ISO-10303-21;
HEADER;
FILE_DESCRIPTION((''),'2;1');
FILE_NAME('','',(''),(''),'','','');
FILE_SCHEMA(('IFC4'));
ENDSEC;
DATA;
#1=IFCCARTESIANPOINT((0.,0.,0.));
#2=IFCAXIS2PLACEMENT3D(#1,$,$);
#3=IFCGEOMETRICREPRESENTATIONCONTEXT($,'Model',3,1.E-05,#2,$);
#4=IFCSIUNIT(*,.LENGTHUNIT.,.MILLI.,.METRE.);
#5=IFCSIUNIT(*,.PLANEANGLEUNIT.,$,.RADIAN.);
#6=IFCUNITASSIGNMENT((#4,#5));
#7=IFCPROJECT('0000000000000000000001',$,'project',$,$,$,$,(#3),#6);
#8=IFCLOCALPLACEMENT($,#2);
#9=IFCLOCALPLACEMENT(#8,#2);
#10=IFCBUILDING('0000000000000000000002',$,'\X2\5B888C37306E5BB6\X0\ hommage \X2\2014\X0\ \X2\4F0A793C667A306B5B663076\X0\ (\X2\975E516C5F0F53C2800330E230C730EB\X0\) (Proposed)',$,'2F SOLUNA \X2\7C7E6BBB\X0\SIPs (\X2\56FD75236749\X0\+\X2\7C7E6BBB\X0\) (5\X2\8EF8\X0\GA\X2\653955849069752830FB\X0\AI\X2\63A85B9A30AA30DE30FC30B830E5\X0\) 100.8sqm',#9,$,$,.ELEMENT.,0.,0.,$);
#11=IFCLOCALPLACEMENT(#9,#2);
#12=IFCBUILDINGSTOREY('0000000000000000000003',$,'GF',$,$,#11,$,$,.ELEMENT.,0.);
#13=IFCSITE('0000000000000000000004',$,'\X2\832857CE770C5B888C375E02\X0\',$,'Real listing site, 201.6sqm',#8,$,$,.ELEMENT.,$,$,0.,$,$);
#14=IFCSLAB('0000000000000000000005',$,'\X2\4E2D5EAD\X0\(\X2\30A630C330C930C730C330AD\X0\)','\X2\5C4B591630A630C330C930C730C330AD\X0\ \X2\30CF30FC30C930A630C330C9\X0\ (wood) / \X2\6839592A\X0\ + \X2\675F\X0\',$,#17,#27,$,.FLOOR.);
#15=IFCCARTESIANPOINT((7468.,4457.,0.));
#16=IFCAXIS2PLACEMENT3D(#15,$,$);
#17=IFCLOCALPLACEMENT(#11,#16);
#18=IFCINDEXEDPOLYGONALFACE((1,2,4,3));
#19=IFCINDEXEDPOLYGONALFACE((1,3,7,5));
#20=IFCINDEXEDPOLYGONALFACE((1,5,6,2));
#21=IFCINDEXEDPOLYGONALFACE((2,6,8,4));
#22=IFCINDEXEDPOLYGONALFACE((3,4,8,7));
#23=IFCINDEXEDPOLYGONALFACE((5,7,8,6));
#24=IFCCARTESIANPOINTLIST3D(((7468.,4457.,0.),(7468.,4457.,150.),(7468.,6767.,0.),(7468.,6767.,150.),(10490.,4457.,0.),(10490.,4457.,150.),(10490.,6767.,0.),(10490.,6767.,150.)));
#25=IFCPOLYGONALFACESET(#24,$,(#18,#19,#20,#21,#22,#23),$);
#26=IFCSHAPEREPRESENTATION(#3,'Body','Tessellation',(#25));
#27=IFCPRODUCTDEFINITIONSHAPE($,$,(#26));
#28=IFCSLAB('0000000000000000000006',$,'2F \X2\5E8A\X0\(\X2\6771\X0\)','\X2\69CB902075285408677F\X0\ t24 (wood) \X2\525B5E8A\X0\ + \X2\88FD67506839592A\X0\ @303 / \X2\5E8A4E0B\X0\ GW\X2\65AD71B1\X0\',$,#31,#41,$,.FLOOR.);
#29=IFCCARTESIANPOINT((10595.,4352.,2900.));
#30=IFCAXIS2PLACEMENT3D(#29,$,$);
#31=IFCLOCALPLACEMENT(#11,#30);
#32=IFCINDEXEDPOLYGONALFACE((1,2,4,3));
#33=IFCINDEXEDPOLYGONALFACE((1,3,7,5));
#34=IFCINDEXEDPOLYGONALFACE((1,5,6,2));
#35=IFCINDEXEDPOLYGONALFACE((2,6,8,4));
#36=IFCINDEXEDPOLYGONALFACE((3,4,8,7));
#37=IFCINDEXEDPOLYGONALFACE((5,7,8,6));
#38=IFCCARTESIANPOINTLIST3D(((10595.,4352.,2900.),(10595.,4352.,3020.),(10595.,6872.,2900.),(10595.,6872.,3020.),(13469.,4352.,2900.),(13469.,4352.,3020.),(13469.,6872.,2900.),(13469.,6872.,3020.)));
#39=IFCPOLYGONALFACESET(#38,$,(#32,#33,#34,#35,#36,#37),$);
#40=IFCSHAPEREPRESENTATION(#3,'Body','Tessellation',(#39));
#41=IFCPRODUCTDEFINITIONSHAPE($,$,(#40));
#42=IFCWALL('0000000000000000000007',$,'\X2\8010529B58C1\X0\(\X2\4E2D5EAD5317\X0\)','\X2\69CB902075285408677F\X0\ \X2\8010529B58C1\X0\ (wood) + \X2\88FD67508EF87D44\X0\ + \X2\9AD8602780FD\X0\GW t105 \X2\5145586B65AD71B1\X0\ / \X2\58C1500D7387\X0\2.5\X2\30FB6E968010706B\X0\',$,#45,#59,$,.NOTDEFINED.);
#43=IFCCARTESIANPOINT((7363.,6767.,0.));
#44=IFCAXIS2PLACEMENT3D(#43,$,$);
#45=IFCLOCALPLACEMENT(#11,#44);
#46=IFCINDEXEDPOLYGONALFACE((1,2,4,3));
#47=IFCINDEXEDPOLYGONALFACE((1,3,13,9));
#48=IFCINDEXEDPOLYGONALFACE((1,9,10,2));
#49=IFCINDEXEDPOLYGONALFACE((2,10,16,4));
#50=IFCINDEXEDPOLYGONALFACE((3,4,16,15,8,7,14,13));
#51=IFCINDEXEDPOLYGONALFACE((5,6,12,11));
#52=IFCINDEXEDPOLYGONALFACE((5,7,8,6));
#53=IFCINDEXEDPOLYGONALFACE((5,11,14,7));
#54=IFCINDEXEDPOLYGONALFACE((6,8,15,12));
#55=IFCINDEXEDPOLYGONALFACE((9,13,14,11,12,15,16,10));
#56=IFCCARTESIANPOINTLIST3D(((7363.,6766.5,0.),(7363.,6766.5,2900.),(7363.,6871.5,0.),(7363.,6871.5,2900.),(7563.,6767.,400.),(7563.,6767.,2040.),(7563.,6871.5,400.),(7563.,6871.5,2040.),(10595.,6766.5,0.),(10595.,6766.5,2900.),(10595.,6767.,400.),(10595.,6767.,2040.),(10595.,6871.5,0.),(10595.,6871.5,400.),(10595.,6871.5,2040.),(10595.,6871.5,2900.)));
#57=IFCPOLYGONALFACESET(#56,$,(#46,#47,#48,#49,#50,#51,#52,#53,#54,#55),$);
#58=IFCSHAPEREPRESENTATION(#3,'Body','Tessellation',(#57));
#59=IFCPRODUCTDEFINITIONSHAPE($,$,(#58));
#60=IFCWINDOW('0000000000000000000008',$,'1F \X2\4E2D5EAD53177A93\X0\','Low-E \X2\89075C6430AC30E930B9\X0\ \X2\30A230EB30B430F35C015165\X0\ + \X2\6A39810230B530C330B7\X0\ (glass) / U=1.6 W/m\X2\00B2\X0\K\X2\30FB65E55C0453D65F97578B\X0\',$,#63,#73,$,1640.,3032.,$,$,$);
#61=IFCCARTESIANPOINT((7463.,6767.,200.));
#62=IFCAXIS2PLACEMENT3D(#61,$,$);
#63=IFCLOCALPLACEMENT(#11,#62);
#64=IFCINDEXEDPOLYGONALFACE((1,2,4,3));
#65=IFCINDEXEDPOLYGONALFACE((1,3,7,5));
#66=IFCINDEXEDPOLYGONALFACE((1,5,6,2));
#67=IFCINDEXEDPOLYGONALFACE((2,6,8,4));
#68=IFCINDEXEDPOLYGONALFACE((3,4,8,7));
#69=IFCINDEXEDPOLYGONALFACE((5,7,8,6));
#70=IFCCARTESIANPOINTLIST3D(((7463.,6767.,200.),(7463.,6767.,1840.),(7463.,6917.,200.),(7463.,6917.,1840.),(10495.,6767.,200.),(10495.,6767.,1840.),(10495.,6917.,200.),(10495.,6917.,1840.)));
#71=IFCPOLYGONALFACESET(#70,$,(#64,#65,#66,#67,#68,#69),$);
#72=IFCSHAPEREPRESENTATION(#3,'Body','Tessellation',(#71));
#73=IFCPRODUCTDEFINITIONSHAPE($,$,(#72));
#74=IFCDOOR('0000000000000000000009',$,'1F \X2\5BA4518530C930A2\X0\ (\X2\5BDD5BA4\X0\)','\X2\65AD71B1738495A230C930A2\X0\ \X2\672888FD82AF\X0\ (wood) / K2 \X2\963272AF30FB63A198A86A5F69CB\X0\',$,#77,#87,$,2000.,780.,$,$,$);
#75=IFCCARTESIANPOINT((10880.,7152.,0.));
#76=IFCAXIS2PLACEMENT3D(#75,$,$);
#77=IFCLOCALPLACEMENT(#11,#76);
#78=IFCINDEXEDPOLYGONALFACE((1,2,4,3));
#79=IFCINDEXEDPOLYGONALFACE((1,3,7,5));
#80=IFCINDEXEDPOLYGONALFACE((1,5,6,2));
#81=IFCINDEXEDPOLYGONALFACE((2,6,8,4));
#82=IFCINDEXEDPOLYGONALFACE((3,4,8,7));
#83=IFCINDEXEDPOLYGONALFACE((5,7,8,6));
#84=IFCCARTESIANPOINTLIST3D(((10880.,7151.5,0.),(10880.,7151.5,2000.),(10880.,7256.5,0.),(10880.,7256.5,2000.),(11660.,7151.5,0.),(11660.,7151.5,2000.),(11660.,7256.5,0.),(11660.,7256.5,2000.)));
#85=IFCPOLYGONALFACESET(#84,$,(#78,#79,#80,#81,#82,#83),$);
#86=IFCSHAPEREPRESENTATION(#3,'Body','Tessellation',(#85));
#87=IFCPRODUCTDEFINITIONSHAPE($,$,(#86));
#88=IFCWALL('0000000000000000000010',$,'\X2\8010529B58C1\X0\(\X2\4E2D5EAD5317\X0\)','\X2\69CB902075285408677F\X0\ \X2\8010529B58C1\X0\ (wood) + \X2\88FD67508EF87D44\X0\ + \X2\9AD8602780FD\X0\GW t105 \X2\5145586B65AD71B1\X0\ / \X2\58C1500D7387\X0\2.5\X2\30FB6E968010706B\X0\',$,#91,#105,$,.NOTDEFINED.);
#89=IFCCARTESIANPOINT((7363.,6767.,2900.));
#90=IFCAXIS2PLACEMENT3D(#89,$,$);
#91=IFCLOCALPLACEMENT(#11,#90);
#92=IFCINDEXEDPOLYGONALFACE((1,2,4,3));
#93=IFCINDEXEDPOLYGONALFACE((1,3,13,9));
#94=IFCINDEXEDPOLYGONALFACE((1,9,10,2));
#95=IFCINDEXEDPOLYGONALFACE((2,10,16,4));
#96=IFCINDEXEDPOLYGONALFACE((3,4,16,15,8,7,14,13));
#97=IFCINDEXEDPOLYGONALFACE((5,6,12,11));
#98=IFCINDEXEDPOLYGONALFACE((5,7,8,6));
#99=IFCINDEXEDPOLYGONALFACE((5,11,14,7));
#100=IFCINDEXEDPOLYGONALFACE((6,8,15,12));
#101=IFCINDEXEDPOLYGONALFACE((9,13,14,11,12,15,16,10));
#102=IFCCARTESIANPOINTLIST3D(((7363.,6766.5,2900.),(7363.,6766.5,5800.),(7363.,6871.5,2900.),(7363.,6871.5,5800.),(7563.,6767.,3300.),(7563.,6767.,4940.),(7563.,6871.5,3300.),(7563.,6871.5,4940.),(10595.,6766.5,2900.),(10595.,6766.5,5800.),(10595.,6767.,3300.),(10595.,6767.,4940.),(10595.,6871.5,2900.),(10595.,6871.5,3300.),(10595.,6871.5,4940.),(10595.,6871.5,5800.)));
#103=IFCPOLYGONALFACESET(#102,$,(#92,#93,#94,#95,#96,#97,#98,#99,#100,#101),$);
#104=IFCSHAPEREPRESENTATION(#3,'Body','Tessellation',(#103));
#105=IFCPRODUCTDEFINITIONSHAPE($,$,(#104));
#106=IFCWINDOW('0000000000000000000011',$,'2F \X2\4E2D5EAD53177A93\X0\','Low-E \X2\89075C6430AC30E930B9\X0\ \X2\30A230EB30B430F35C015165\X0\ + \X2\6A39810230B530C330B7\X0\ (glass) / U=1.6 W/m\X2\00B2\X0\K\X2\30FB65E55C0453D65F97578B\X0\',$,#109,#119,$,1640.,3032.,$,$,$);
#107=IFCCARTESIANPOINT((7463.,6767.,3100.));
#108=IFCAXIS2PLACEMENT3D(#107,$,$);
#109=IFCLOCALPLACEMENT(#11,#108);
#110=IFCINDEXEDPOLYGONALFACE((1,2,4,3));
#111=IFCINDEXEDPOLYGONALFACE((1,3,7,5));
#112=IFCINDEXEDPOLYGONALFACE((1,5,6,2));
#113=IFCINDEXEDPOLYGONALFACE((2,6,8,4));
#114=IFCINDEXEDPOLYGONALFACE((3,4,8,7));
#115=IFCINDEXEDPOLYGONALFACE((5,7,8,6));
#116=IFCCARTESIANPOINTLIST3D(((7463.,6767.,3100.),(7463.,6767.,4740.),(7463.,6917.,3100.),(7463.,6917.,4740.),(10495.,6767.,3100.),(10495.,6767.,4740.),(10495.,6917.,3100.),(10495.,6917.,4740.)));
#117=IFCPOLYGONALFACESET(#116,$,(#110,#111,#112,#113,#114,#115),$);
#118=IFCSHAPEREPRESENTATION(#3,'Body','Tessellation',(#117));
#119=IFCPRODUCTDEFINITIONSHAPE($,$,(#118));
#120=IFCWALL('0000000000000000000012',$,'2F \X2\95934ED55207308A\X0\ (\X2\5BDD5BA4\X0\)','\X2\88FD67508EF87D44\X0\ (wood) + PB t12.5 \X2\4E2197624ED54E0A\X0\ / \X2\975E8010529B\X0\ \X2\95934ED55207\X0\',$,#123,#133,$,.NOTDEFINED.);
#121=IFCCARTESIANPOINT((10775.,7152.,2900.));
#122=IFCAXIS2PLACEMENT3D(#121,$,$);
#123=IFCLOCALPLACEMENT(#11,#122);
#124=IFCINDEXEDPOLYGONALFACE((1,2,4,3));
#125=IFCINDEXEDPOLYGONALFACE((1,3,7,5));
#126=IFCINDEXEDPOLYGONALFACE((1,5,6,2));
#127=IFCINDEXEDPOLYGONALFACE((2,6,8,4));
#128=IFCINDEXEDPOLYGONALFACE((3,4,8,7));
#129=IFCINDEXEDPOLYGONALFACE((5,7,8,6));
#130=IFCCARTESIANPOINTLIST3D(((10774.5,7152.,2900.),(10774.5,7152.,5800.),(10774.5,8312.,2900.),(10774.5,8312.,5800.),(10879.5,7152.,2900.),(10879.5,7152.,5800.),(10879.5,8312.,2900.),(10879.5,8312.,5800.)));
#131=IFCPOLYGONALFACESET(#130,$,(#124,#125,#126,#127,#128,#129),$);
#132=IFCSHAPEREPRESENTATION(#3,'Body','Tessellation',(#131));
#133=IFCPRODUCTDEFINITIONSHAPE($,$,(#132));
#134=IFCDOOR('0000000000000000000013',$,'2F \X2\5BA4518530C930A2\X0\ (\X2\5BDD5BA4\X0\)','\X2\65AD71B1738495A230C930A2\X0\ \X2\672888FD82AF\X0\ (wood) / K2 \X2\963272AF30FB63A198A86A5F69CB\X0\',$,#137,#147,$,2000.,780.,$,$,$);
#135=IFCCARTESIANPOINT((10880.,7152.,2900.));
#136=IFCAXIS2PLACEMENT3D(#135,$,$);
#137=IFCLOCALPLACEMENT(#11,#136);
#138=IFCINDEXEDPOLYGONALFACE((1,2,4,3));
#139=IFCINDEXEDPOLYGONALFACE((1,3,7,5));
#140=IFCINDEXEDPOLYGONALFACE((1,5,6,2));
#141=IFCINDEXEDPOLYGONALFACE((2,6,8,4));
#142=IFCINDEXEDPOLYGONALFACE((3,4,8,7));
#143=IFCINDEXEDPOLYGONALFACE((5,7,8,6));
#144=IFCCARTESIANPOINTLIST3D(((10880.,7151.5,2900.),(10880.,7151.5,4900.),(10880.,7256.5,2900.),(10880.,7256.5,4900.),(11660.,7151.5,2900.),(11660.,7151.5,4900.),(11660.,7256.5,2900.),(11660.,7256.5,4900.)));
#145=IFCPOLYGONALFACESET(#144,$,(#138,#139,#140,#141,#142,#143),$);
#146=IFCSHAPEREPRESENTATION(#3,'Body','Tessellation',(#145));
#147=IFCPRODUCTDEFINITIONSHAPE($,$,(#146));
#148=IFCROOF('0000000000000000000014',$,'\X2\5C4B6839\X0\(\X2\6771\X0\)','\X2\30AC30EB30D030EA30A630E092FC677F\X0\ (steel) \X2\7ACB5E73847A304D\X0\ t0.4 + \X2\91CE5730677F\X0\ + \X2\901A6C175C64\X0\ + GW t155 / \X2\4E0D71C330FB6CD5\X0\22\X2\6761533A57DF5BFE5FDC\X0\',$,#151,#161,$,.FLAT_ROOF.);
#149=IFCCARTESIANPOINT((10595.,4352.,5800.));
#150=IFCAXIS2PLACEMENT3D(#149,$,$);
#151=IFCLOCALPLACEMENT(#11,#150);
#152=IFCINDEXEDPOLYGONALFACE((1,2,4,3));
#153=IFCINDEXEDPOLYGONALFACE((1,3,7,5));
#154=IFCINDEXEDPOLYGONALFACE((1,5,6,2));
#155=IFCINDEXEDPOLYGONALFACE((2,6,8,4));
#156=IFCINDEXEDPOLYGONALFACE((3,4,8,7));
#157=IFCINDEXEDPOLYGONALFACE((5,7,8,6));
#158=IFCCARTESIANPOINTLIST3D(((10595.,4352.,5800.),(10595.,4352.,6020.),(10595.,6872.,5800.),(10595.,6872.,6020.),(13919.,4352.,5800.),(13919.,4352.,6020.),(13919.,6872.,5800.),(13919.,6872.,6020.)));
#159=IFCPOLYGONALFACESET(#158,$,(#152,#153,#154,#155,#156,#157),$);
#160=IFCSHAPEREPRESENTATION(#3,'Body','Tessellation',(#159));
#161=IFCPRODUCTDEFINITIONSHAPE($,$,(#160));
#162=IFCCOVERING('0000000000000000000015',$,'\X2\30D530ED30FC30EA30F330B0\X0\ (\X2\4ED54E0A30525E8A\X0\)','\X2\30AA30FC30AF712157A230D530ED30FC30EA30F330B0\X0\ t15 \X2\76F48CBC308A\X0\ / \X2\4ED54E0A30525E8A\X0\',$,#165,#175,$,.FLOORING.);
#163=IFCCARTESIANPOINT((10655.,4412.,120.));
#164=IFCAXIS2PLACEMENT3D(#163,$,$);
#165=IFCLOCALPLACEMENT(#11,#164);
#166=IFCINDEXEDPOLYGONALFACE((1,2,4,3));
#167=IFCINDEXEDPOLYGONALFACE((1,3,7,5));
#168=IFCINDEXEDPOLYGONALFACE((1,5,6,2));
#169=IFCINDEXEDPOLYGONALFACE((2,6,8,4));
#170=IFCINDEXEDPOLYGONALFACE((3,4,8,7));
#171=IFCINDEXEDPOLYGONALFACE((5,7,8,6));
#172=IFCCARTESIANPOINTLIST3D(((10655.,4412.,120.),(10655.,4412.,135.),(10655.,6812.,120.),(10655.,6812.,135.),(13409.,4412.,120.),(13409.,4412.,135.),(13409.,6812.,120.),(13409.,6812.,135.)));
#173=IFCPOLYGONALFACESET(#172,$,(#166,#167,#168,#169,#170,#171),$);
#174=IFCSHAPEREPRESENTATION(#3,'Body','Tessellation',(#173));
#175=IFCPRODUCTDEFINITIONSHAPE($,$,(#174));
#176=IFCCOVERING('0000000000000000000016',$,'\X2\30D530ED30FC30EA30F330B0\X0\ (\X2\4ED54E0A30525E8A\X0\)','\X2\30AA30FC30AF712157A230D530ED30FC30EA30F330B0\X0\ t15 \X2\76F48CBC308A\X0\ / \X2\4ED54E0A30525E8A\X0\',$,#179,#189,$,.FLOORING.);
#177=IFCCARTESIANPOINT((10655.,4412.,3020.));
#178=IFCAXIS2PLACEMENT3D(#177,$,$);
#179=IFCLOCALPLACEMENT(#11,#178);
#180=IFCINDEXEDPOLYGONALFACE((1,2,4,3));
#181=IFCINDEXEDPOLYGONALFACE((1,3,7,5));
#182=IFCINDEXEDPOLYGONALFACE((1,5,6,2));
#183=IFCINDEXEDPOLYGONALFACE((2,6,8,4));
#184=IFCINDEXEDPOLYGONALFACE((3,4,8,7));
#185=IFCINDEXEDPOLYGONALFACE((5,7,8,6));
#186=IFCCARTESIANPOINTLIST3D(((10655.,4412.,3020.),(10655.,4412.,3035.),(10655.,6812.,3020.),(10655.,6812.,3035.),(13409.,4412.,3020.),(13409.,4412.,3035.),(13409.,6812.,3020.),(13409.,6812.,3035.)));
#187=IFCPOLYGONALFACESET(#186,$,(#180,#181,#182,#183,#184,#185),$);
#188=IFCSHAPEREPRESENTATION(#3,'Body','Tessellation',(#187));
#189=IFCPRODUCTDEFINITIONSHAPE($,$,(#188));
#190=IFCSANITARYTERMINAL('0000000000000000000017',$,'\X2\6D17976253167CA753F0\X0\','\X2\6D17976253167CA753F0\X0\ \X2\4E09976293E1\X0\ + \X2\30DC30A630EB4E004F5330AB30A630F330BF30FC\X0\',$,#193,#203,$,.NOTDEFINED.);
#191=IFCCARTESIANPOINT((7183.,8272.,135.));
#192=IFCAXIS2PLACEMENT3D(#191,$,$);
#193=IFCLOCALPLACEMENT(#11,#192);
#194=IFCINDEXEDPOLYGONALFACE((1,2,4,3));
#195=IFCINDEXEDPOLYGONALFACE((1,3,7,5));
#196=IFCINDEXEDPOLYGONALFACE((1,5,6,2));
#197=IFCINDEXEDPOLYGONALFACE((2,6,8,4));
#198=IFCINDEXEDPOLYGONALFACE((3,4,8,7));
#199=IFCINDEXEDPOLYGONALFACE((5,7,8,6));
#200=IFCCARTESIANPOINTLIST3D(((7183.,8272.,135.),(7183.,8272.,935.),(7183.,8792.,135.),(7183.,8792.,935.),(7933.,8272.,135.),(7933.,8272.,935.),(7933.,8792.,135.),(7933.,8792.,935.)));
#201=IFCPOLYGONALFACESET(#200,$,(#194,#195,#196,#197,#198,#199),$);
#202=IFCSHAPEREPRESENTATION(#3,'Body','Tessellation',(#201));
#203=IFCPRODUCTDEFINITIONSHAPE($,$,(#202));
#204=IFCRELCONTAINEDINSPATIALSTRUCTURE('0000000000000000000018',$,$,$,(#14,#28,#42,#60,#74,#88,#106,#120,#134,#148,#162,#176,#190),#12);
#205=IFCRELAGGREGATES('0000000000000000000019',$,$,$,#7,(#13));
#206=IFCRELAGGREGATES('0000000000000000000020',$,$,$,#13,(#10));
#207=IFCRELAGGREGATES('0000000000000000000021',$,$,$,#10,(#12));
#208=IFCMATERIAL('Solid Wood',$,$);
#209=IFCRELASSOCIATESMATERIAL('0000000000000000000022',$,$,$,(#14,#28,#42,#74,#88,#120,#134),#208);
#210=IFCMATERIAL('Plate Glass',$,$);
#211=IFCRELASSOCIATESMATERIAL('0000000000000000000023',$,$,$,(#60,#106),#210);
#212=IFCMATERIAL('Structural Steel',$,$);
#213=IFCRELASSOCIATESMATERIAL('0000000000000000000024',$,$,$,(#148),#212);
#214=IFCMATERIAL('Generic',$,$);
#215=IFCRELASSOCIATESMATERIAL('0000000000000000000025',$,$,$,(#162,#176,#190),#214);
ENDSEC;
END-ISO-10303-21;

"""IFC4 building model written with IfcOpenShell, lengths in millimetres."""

from ifc_helpers import new_model, si_unit, frame, frame_2d, origin, place, context, project, spatial, rectangle, extrude, material, element, fill, save


model = new_model("IFC4")

# Units and contexts
model_context = context("Model", 3, precision=1e-05, world=origin())
ifc_project = project(units=[si_unit("LENGTHUNIT", "METRE", prefix="MILLI"), si_unit("PLANEANGLEUNIT", "RADIAN")], contexts=[model_context])

# Site, building, storey
site_placement = place(None, origin())
site = spatial("IfcSite", under=ifc_project, at=site_placement, Name="茨城県守谷市", ObjectType="Real listing site, 201.6sqm", CompositionType="ELEMENT", RefElevation=0.0)
building_placement = place(site_placement, origin())
building = spatial("IfcBuilding", under=site, at=building_placement, Name="守谷の家 hommage — 伊礼智に学ぶ (非公式参考モデル) (Proposed)", ObjectType="2F SOLUNA 籾殻SIPs (国産杉+籾殻) (5軸GA改善適用・AI推定オマージュ) 100.8sqm", CompositionType="ELEMENT", ElevationOfRefHeight=0.0, ElevationOfTerrain=0.0)
storey_placement = place(building_placement, origin())
storey = spatial("IfcBuildingStorey", under=building, at=storey_placement, Name="GF", CompositionType="ELEMENT", Elevation=0.0)

# Slabs
ifc_material_1 = material(Name="Solid Wood")
slab_1_placement = place(storey_placement, frame((7468.0, 4457.0, 0.0)))
element("IfcSlab", 1, at=slab_1_placement, inside=storey, material=ifc_material_1, Name="中庭(ウッドデッキ)", Description="屋外ウッドデッキ ハードウッド (wood) / 根太 + 束", PredefinedType="FLOOR", context=model_context, shape_type="SweptSolid", body=[
    extrude(rectangle(XDim=3022.0, YDim=2310.0, at=frame_2d((1511.0, 1155.0))), frame((7468.0, 4457.0, 0.0)), (0.0, 0.0, 1.0), 150.0),
])
slab_2_placement = place(storey_placement, frame((10595.0, 4352.0, 2900.0)))
element("IfcSlab", 2, at=slab_2_placement, inside=storey, material=ifc_material_1, Name="2F 床(東)", Description="構造用合板 t24 (wood) 剛床 + 製材根太 @303 / 床下 GW断熱", PredefinedType="FLOOR", context=model_context, shape_type="SweptSolid", body=[
    extrude(rectangle(XDim=2874.0, YDim=2520.0, at=frame_2d((1437.0, 1260.0))), frame((10595.0, 4352.0, 2900.0)), (0.0, 0.0, 1.0), 120.0),
])

# Wall, opening, window
wall_1_placement = place(storey_placement, frame((7363.0, 6767.0, 0.0)))
wall_1 = element("IfcWall", 3, at=wall_1_placement, inside=storey, material=ifc_material_1, Name="耐力壁(中庭北)", Description="構造用合板 耐力壁 (wood) + 製材軸組 + 高性能GW t105 充填断熱 / 壁倍率2.5・準耐火", PredefinedType="NOTDEFINED", context=model_context, shape_type="SweptSolid", body=[
    extrude(rectangle(XDim=3232.0, YDim=105.0, at=frame_2d((1616.0, 52.0))), frame((7363.0, 6767.0, 0.0)), (0.0, 0.0, 1.0), 2900.0),
])
opening_1_placement = place(storey_placement, frame((7463.0, 6767.0, 200.0)))
opening_1 = element("IfcOpeningElement", 4, at=opening_1_placement, cuts=wall_1, PredefinedType="NOTDEFINED", context=model_context, shape_type="SweptSolid", body=[
    extrude(rectangle(XDim=3032.0, YDim=150.0, at=frame_2d((1516.0, 75.0))), frame((7463.0, 6767.0, 200.0)), (0.0, 0.0, 1.0), 1640.0),
])
ifc_material_2 = material(Name="Plate Glass")
window_1_placement = place(storey_placement, frame((7463.0, 6767.0, 200.0)))
window_1 = element("IfcWindow", 5, at=window_1_placement, inside=storey, material=ifc_material_2, Name="1F 中庭北窓", Description="Low-E 複層ガラス アルゴン封入 + 樹脂サッシ (glass) / U=1.6 W/m²K・日射取得型", OverallHeight=1640.0, OverallWidth=3032.0, context=model_context, shape_type="SweptSolid", body=[
    extrude(rectangle(XDim=3032.0, YDim=150.0, at=frame_2d((1516.0, 75.0))), frame((7463.0, 6767.0, 200.0)), (0.0, 0.0, 1.0), 1640.0),
])
fill(opening_1, window_1)

# Door
door_1_placement = place(storey_placement, frame((10880.0, 7152.0, 0.0)))
element("IfcDoor", 6, at=door_1_placement, inside=storey, material=ifc_material_1, Name="1F 室内ドア (寝室)", Description="断熱玄関ドア 木製芯 (wood) / K2 防犯・採風機構", OverallHeight=2000.0, OverallWidth=780.0, context=model_context, shape_type="SweptSolid", body=[
    extrude(rectangle(XDim=780.0, YDim=105.0, at=frame_2d((390.0, 52.0))), frame((10880.0, 7152.0, 0.0)), (0.0, 0.0, 1.0), 2000.0),
])

# Wall, opening, window
wall_2_placement = place(storey_placement, frame((7363.0, 6767.0, 2900.0)))
wall_2 = element("IfcWall", 7, at=wall_2_placement, inside=storey, material=ifc_material_1, Name="耐力壁(中庭北)", Description="構造用合板 耐力壁 (wood) + 製材軸組 + 高性能GW t105 充填断熱 / 壁倍率2.5・準耐火", PredefinedType="NOTDEFINED", context=model_context, shape_type="SweptSolid", body=[
    extrude(rectangle(XDim=3232.0, YDim=105.0, at=frame_2d((1616.0, 52.0))), frame((7363.0, 6767.0, 2900.0)), (0.0, 0.0, 1.0), 2900.0),
])
opening_2_placement = place(storey_placement, frame((7463.0, 6767.0, 3100.0)))
opening_2 = element("IfcOpeningElement", 8, at=opening_2_placement, cuts=wall_2, PredefinedType="NOTDEFINED", context=model_context, shape_type="SweptSolid", body=[
    extrude(rectangle(XDim=3032.0, YDim=150.0, at=frame_2d((1516.0, 75.0))), frame((7463.0, 6767.0, 3100.0)), (0.0, 0.0, 1.0), 1640.0),
])
window_2_placement = place(storey_placement, frame((7463.0, 6767.0, 3100.0)))
window_2 = element("IfcWindow", 9, at=window_2_placement, inside=storey, material=ifc_material_2, Name="2F 中庭北窓", Description="Low-E 複層ガラス アルゴン封入 + 樹脂サッシ (glass) / U=1.6 W/m²K・日射取得型", OverallHeight=1640.0, OverallWidth=3032.0, context=model_context, shape_type="SweptSolid", body=[
    extrude(rectangle(XDim=3032.0, YDim=150.0, at=frame_2d((1516.0, 75.0))), frame((7463.0, 6767.0, 3100.0)), (0.0, 0.0, 1.0), 1640.0),
])
fill(opening_2, window_2)

# Wall
wall_3_placement = place(storey_placement, frame((10775.0, 7152.0, 2900.0)))
element("IfcWall", 10, at=wall_3_placement, inside=storey, material=ifc_material_1, Name="2F 間仕切り (寝室)", Description="製材軸組 (wood) + PB t12.5 両面仕上 / 非耐力 間仕切", PredefinedType="NOTDEFINED", context=model_context, shape_type="SweptSolid", body=[
    extrude(rectangle(XDim=105.0, YDim=1160.0, at=frame_2d((52.0, 580.0))), frame((10775.0, 7152.0, 2900.0)), (0.0, 0.0, 1.0), 2900.0),
])

# Door
door_2_placement = place(storey_placement, frame((10880.0, 7152.0, 2900.0)))
element("IfcDoor", 11, at=door_2_placement, inside=storey, material=ifc_material_1, Name="2F 室内ドア (寝室)", Description="断熱玄関ドア 木製芯 (wood) / K2 防犯・採風機構", OverallHeight=2000.0, OverallWidth=780.0, context=model_context, shape_type="SweptSolid", body=[
    extrude(rectangle(XDim=780.0, YDim=105.0, at=frame_2d((390.0, 52.0))), frame((10880.0, 7152.0, 2900.0)), (0.0, 0.0, 1.0), 2000.0),
])

# Roof
ifc_material_3 = material(Name="Structural Steel")
for number, where, name in (
    (12, (10595.0, 4352.0, 5800.0), "屋根(東)"),
):
    element("IfcRoof", number, at=place(storey_placement, frame(where)), inside=storey, material=ifc_material_3, Name=name, Description="ガルバリウム鋼板 (steel) 立平葺き t0.4 + 野地板 + 通気層 + GW t155 / 不燃・法22条区域対応", PredefinedType="FLAT_ROOF", context=model_context, shape_type="SweptSolid", body=[
        extrude(rectangle(XDim=3324.0, YDim=2520.0, at=frame_2d((1662.0, 1260.0))), frame((10595.0, 4352.0, 5800.0)), (0.0, 0.0, 1.0), 220.0),
    ])

# Coverings
ifc_material_4 = material(Name="Generic")
covering_1_placement = place(storey_placement, frame((10655.0, 4412.0, 120.0)))
element("IfcCovering", 13, at=covering_1_placement, inside=storey, material=ifc_material_4, Name="フローリング (仕上げ床)", Description="オーク無垢フローリング t15 直貼り / 仕上げ床", PredefinedType="FLOORING", context=model_context, shape_type="SweptSolid", body=[
    extrude(rectangle(XDim=2754.0, YDim=2400.0, at=frame_2d((1377.0, 1200.0))), frame((10655.0, 4412.0, 120.0)), (0.0, 0.0, 1.0), 15.0),
])
covering_2_placement = place(storey_placement, frame((10655.0, 4412.0, 3020.0)))
element("IfcCovering", 14, at=covering_2_placement, inside=storey, material=ifc_material_4, Name="フローリング (仕上げ床)", Description="オーク無垢フローリング t15 直貼り / 仕上げ床", PredefinedType="FLOORING", context=model_context, shape_type="SweptSolid", body=[
    extrude(rectangle(XDim=2754.0, YDim=2400.0, at=frame_2d((1377.0, 1200.0))), frame((10655.0, 4412.0, 3020.0)), (0.0, 0.0, 1.0), 15.0),
])

# Sanitary terminal
sanitary_terminal_1_placement = place(storey_placement, frame((7183.0, 8272.0, 135.0)))
element("IfcSanitaryTerminal", 15, at=sanitary_terminal_1_placement, inside=storey, material=ifc_material_4, Name="洗面化粧台", Description="洗面化粧台 三面鏡 + ボウル一体カウンター", PredefinedType="NOTDEFINED", context=model_context, shape_type="SweptSolid", body=[
    extrude(rectangle(XDim=750.0, YDim=520.0, at=frame_2d((375.0, 260.0))), frame((7183.0, 8272.0, 135.0)), (0.0, 0.0, 1.0), 800.0),
])

save(model, "model.ifc")
